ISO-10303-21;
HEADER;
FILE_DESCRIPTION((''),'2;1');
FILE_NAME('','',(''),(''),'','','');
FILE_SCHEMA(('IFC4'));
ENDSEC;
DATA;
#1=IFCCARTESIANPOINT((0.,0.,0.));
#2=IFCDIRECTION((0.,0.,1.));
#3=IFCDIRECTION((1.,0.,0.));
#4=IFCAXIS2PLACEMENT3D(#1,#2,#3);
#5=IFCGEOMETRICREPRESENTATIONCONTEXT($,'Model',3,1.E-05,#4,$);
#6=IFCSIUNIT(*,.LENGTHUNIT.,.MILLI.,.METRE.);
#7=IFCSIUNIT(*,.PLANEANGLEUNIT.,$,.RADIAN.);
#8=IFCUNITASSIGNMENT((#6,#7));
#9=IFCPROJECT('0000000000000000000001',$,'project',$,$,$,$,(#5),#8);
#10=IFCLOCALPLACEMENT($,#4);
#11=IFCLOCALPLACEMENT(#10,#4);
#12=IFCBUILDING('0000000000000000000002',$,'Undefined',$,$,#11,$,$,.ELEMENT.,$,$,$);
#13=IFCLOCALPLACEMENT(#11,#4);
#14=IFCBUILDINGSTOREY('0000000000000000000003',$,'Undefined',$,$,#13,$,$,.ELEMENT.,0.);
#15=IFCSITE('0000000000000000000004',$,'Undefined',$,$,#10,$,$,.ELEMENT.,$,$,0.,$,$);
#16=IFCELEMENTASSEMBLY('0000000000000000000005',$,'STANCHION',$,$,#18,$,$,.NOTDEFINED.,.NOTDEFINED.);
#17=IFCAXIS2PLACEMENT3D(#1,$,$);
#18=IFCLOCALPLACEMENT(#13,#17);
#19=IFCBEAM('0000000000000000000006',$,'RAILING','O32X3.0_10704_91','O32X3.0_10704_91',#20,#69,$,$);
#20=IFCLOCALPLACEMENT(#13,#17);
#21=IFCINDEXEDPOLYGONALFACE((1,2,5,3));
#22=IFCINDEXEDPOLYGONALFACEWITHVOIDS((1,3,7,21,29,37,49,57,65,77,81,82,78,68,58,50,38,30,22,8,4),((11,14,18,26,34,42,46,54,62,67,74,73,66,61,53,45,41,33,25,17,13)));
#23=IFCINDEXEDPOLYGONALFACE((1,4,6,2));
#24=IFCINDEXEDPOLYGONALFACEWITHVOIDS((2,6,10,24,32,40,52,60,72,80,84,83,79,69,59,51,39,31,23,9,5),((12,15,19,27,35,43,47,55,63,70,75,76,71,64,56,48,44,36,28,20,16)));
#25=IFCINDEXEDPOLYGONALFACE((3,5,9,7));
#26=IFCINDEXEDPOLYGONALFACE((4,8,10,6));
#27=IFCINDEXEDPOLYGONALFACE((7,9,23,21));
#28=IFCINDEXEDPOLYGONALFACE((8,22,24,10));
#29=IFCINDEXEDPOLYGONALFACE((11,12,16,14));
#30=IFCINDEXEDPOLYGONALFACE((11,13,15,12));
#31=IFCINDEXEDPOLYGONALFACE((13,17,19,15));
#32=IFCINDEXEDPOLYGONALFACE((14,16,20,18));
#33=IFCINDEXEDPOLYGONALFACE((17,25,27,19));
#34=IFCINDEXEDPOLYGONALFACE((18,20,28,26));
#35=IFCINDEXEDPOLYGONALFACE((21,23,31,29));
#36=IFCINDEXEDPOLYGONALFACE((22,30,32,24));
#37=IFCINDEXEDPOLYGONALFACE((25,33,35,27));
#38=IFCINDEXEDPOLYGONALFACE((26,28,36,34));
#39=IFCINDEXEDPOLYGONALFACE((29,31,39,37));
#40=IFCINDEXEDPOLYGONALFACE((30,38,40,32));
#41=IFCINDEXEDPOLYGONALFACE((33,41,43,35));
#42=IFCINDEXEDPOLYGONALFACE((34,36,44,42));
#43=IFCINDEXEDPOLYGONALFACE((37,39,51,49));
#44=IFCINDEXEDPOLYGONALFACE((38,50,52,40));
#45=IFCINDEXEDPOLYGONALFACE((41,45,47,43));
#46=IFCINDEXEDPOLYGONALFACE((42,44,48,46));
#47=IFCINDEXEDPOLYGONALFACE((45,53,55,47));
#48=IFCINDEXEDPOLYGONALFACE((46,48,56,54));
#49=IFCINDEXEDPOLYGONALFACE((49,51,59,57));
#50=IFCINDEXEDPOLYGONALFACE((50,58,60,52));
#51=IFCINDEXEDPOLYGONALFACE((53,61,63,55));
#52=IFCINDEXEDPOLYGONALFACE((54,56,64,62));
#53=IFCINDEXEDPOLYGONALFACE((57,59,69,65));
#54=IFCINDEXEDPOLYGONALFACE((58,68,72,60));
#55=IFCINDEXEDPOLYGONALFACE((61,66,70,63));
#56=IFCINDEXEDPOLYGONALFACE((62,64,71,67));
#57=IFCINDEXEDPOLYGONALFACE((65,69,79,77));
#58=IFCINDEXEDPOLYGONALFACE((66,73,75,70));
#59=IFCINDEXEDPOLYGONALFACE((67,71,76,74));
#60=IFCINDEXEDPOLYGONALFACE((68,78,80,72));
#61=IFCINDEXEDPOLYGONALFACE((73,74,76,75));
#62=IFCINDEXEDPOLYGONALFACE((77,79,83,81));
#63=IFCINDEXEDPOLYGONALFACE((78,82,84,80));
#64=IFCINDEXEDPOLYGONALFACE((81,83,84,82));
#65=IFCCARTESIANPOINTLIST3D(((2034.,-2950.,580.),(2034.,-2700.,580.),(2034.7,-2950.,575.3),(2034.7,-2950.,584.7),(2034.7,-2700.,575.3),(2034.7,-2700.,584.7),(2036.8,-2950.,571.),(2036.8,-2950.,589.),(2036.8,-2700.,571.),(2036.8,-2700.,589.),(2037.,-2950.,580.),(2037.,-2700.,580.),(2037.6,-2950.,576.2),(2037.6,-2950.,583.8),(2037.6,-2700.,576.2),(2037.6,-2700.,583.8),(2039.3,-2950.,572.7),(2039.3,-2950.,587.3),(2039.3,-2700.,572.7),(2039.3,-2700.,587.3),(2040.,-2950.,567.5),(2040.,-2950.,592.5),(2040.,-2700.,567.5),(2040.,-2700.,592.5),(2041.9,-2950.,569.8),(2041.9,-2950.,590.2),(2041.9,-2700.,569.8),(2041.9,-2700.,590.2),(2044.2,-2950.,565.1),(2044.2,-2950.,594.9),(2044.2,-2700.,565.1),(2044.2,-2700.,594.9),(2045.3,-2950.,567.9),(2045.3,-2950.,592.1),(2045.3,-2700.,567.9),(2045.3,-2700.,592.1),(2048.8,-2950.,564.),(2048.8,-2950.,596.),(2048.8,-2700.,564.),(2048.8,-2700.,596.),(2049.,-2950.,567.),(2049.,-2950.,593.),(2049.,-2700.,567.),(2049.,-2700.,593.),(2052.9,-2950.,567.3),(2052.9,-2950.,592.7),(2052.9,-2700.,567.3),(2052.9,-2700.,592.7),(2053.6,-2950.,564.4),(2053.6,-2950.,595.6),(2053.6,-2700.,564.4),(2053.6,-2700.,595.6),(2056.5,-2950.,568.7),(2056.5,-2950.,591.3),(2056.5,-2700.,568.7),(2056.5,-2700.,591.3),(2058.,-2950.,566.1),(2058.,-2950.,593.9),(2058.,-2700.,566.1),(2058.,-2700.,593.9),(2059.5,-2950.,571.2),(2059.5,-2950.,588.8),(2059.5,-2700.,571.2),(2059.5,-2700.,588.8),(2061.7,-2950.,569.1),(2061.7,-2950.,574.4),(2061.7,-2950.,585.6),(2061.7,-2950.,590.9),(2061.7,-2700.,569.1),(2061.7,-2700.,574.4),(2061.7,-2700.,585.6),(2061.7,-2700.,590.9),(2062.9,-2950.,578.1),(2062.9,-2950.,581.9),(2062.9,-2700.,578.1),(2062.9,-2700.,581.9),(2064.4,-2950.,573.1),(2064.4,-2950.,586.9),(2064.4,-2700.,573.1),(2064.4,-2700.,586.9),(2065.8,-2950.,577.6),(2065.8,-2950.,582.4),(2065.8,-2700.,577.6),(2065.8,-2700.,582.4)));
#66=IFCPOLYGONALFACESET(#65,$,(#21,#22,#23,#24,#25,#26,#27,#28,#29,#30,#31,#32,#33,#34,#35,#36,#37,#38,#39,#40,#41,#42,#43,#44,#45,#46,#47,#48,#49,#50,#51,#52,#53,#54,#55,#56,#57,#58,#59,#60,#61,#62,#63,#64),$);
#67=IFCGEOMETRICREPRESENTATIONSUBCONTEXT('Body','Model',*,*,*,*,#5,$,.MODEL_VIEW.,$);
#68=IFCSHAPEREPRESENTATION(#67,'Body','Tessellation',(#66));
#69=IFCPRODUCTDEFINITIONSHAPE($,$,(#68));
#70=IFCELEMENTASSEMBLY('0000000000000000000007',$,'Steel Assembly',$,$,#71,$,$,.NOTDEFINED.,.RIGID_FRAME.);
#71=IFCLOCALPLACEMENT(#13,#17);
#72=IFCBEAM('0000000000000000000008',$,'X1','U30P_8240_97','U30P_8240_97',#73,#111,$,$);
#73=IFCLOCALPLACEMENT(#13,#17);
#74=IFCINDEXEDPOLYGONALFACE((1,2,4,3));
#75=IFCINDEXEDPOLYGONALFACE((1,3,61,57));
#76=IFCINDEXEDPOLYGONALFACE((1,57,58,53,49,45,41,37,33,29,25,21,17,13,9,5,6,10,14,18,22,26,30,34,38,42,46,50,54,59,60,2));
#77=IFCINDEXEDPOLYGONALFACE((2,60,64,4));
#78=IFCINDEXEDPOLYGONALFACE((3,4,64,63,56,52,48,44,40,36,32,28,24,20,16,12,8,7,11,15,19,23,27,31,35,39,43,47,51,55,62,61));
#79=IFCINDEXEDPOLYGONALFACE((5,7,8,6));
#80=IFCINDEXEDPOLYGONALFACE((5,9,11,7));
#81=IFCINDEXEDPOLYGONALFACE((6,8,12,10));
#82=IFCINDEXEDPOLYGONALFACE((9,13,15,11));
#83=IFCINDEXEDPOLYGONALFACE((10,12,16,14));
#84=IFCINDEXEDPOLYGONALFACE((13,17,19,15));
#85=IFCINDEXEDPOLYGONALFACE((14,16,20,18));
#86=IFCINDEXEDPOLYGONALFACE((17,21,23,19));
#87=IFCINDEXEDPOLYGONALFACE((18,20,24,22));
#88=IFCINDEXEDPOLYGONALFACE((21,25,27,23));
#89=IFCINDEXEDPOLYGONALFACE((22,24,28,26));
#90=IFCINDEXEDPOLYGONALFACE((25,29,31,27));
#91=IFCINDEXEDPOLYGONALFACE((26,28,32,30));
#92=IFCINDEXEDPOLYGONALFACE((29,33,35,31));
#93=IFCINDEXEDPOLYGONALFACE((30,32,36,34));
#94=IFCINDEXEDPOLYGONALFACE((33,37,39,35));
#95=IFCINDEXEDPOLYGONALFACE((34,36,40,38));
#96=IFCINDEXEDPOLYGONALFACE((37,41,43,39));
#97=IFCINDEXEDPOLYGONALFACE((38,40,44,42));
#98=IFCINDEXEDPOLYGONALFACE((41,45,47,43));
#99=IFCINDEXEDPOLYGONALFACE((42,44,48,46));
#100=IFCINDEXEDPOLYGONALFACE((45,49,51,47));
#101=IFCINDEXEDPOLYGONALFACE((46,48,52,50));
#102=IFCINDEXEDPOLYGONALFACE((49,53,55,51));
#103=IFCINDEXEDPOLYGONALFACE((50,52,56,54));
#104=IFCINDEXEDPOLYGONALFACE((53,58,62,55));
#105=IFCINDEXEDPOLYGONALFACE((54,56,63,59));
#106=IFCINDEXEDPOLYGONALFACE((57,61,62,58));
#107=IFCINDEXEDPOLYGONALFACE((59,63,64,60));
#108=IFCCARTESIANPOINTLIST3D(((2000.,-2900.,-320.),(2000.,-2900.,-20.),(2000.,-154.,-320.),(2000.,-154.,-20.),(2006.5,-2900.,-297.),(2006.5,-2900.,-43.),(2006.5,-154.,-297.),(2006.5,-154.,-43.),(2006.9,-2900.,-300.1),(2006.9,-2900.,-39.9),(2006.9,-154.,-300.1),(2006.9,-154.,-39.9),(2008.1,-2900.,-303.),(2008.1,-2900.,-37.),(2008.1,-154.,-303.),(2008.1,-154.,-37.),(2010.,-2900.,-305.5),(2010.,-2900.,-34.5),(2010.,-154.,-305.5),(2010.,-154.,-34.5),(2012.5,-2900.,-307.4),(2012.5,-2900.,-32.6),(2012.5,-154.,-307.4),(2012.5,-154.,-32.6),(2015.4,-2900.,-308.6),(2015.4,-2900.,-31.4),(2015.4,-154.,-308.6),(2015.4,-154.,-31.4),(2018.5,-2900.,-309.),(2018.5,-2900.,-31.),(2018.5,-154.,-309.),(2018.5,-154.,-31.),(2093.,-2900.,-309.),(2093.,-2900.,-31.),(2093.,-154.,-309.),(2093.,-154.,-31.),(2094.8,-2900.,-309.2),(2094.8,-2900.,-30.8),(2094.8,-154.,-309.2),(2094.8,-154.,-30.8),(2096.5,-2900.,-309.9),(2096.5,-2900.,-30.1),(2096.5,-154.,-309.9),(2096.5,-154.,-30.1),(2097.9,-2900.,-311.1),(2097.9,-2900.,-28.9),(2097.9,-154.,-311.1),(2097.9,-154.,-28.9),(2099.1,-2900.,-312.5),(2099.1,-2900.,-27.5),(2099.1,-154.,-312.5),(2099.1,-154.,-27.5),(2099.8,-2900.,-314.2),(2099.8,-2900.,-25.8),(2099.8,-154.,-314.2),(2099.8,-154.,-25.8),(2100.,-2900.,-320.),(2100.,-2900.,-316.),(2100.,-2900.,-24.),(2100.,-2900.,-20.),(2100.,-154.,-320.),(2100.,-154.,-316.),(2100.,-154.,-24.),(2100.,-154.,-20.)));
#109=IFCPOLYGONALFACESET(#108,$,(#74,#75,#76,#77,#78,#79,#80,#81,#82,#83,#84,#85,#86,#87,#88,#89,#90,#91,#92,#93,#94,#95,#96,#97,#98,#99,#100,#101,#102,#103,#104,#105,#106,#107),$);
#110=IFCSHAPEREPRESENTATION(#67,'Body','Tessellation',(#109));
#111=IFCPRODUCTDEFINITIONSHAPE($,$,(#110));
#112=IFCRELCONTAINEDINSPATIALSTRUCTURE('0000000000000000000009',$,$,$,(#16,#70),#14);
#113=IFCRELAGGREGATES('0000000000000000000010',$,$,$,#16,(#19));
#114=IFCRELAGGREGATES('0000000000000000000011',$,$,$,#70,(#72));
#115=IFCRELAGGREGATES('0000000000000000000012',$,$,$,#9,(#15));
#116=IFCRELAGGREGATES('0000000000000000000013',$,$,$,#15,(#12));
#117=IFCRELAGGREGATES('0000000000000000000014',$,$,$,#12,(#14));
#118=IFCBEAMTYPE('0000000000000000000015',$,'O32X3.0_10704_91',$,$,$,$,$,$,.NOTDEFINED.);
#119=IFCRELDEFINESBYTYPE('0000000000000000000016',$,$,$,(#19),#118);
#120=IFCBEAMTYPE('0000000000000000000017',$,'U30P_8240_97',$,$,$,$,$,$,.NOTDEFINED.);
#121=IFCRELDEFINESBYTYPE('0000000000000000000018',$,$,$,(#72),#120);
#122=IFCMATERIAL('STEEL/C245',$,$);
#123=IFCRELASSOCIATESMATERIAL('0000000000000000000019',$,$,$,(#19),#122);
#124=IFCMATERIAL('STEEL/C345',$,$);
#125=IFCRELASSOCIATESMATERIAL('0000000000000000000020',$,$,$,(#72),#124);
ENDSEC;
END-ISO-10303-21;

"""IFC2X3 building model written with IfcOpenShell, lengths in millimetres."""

from ifc_helpers import new_model, si_unit, frame, origin_with_axes, origin_2d_with_axis, place, context, subcontext, project, spatial, hollow_circle, u_section, extrude, material, type_object, element, aggregate, save


model = new_model("IFC2X3")

# Units and contexts
model_context = context("Model", 3, precision=1e-05, world=origin_with_axes())
body_context = subcontext(model_context, "Body", "Model", "MODEL_VIEW")
ifc_project = project(units=[si_unit("LENGTHUNIT", "METRE", prefix="MILLI"), si_unit("PLANEANGLEUNIT", "RADIAN")], contexts=[model_context])

# Site, building, storey
site_placement = place(None, origin_with_axes())
site = spatial("IfcSite", under=ifc_project, at=site_placement, Name="Undefined", CompositionType="ELEMENT", RefElevation=0.0)
building_placement = place(site_placement, origin_with_axes())
building = spatial("IfcBuilding", under=site, at=building_placement, Name="Undefined", CompositionType="ELEMENT")
storey_placement = place(building_placement, origin_with_axes())
storey = spatial("IfcBuildingStorey", under=building, at=storey_placement, Name="Undefined", CompositionType="ELEMENT", Elevation=0.0)

# Shared definitions
ifc_material_1 = material(Name="STEEL/C245")

# Element assembly
assembly_1_placement = place(storey_placement, origin_with_axes())
assembly_1 = element("IfcElementAssembly", 1, at=assembly_1_placement, inside=storey, Name="STANCHION", AssemblyPlace="NOTDEFINED", PredefinedType="NOTDEFINED")

# Beam
beam_type_1 = type_object("IfcBeamType", Name="O32X3.0_10704_91", PredefinedType="NOTDEFINED")
beam_1_placement = place(assembly_1_placement, frame((2050.0, -2950.0, 580.0), z_axis=(0.0, 0.0, -1.0), x_axis=(0.0, 1.0, 0.0)))
beam_1 = element("IfcBeam", 2, at=beam_1_placement, type_object=beam_type_1, material=ifc_material_1, Name="RAILING", Description="O32X3.0_10704_91", ObjectType="O32X3.0_10704_91", context=body_context, shape_type="SweptSolid", body=[
    extrude(hollow_circle(Radius=16.0, WallThickness=3.0, at=origin_2d_with_axis()), frame((250.0, 0.0, 0.0), z_axis=(-1.0, 0.0, 0.0), x_axis=(0.0, -1.0, 0.0)), (0.0, 0.0, 1.0), 250.0),
])
aggregate(assembly_1, [beam_1])

# Element assembly, beam
assembly_2_placement = place(storey_placement, origin_with_axes())
assembly_2 = element("IfcElementAssembly", 3, at=assembly_2_placement, inside=storey, Name="Steel Assembly", AssemblyPlace="NOTDEFINED", PredefinedType="RIGID_FRAME")
ifc_material_2 = material(Name="STEEL/C345")
beam_type_2 = type_object("IfcBeamType", Name="U30P_8240_97", PredefinedType="NOTDEFINED")
beam_2_placement = place(assembly_2_placement, frame((2050.0, -154.0, -170.0), z_axis=(0.0, 0.0, -1.0), x_axis=(0.0, -1.0, 0.0)))
beam_2 = element("IfcBeam", 4, at=beam_2_placement, type_object=beam_type_2, material=ifc_material_2, Name="X1", Description="U30P_8240_97", ObjectType="U30P_8240_97", context=body_context, shape_type="SweptSolid", body=[
    extrude(u_section(Depth=300.0, FlangeWidth=100.0, WebThickness=6.5, FlangeThickness=11.0, FilletRadius=12.0, EdgeRadius=7.0, at=origin_2d_with_axis()), frame((2746.0, 0.0, 0.0), z_axis=(-1.0, 0.0, 0.0), x_axis=(0.0, -1.0, 0.0)), (0.0, 0.0, 1.0), 2746.0),
])
aggregate(assembly_2, [beam_2])

save(model, "model.ifc")
